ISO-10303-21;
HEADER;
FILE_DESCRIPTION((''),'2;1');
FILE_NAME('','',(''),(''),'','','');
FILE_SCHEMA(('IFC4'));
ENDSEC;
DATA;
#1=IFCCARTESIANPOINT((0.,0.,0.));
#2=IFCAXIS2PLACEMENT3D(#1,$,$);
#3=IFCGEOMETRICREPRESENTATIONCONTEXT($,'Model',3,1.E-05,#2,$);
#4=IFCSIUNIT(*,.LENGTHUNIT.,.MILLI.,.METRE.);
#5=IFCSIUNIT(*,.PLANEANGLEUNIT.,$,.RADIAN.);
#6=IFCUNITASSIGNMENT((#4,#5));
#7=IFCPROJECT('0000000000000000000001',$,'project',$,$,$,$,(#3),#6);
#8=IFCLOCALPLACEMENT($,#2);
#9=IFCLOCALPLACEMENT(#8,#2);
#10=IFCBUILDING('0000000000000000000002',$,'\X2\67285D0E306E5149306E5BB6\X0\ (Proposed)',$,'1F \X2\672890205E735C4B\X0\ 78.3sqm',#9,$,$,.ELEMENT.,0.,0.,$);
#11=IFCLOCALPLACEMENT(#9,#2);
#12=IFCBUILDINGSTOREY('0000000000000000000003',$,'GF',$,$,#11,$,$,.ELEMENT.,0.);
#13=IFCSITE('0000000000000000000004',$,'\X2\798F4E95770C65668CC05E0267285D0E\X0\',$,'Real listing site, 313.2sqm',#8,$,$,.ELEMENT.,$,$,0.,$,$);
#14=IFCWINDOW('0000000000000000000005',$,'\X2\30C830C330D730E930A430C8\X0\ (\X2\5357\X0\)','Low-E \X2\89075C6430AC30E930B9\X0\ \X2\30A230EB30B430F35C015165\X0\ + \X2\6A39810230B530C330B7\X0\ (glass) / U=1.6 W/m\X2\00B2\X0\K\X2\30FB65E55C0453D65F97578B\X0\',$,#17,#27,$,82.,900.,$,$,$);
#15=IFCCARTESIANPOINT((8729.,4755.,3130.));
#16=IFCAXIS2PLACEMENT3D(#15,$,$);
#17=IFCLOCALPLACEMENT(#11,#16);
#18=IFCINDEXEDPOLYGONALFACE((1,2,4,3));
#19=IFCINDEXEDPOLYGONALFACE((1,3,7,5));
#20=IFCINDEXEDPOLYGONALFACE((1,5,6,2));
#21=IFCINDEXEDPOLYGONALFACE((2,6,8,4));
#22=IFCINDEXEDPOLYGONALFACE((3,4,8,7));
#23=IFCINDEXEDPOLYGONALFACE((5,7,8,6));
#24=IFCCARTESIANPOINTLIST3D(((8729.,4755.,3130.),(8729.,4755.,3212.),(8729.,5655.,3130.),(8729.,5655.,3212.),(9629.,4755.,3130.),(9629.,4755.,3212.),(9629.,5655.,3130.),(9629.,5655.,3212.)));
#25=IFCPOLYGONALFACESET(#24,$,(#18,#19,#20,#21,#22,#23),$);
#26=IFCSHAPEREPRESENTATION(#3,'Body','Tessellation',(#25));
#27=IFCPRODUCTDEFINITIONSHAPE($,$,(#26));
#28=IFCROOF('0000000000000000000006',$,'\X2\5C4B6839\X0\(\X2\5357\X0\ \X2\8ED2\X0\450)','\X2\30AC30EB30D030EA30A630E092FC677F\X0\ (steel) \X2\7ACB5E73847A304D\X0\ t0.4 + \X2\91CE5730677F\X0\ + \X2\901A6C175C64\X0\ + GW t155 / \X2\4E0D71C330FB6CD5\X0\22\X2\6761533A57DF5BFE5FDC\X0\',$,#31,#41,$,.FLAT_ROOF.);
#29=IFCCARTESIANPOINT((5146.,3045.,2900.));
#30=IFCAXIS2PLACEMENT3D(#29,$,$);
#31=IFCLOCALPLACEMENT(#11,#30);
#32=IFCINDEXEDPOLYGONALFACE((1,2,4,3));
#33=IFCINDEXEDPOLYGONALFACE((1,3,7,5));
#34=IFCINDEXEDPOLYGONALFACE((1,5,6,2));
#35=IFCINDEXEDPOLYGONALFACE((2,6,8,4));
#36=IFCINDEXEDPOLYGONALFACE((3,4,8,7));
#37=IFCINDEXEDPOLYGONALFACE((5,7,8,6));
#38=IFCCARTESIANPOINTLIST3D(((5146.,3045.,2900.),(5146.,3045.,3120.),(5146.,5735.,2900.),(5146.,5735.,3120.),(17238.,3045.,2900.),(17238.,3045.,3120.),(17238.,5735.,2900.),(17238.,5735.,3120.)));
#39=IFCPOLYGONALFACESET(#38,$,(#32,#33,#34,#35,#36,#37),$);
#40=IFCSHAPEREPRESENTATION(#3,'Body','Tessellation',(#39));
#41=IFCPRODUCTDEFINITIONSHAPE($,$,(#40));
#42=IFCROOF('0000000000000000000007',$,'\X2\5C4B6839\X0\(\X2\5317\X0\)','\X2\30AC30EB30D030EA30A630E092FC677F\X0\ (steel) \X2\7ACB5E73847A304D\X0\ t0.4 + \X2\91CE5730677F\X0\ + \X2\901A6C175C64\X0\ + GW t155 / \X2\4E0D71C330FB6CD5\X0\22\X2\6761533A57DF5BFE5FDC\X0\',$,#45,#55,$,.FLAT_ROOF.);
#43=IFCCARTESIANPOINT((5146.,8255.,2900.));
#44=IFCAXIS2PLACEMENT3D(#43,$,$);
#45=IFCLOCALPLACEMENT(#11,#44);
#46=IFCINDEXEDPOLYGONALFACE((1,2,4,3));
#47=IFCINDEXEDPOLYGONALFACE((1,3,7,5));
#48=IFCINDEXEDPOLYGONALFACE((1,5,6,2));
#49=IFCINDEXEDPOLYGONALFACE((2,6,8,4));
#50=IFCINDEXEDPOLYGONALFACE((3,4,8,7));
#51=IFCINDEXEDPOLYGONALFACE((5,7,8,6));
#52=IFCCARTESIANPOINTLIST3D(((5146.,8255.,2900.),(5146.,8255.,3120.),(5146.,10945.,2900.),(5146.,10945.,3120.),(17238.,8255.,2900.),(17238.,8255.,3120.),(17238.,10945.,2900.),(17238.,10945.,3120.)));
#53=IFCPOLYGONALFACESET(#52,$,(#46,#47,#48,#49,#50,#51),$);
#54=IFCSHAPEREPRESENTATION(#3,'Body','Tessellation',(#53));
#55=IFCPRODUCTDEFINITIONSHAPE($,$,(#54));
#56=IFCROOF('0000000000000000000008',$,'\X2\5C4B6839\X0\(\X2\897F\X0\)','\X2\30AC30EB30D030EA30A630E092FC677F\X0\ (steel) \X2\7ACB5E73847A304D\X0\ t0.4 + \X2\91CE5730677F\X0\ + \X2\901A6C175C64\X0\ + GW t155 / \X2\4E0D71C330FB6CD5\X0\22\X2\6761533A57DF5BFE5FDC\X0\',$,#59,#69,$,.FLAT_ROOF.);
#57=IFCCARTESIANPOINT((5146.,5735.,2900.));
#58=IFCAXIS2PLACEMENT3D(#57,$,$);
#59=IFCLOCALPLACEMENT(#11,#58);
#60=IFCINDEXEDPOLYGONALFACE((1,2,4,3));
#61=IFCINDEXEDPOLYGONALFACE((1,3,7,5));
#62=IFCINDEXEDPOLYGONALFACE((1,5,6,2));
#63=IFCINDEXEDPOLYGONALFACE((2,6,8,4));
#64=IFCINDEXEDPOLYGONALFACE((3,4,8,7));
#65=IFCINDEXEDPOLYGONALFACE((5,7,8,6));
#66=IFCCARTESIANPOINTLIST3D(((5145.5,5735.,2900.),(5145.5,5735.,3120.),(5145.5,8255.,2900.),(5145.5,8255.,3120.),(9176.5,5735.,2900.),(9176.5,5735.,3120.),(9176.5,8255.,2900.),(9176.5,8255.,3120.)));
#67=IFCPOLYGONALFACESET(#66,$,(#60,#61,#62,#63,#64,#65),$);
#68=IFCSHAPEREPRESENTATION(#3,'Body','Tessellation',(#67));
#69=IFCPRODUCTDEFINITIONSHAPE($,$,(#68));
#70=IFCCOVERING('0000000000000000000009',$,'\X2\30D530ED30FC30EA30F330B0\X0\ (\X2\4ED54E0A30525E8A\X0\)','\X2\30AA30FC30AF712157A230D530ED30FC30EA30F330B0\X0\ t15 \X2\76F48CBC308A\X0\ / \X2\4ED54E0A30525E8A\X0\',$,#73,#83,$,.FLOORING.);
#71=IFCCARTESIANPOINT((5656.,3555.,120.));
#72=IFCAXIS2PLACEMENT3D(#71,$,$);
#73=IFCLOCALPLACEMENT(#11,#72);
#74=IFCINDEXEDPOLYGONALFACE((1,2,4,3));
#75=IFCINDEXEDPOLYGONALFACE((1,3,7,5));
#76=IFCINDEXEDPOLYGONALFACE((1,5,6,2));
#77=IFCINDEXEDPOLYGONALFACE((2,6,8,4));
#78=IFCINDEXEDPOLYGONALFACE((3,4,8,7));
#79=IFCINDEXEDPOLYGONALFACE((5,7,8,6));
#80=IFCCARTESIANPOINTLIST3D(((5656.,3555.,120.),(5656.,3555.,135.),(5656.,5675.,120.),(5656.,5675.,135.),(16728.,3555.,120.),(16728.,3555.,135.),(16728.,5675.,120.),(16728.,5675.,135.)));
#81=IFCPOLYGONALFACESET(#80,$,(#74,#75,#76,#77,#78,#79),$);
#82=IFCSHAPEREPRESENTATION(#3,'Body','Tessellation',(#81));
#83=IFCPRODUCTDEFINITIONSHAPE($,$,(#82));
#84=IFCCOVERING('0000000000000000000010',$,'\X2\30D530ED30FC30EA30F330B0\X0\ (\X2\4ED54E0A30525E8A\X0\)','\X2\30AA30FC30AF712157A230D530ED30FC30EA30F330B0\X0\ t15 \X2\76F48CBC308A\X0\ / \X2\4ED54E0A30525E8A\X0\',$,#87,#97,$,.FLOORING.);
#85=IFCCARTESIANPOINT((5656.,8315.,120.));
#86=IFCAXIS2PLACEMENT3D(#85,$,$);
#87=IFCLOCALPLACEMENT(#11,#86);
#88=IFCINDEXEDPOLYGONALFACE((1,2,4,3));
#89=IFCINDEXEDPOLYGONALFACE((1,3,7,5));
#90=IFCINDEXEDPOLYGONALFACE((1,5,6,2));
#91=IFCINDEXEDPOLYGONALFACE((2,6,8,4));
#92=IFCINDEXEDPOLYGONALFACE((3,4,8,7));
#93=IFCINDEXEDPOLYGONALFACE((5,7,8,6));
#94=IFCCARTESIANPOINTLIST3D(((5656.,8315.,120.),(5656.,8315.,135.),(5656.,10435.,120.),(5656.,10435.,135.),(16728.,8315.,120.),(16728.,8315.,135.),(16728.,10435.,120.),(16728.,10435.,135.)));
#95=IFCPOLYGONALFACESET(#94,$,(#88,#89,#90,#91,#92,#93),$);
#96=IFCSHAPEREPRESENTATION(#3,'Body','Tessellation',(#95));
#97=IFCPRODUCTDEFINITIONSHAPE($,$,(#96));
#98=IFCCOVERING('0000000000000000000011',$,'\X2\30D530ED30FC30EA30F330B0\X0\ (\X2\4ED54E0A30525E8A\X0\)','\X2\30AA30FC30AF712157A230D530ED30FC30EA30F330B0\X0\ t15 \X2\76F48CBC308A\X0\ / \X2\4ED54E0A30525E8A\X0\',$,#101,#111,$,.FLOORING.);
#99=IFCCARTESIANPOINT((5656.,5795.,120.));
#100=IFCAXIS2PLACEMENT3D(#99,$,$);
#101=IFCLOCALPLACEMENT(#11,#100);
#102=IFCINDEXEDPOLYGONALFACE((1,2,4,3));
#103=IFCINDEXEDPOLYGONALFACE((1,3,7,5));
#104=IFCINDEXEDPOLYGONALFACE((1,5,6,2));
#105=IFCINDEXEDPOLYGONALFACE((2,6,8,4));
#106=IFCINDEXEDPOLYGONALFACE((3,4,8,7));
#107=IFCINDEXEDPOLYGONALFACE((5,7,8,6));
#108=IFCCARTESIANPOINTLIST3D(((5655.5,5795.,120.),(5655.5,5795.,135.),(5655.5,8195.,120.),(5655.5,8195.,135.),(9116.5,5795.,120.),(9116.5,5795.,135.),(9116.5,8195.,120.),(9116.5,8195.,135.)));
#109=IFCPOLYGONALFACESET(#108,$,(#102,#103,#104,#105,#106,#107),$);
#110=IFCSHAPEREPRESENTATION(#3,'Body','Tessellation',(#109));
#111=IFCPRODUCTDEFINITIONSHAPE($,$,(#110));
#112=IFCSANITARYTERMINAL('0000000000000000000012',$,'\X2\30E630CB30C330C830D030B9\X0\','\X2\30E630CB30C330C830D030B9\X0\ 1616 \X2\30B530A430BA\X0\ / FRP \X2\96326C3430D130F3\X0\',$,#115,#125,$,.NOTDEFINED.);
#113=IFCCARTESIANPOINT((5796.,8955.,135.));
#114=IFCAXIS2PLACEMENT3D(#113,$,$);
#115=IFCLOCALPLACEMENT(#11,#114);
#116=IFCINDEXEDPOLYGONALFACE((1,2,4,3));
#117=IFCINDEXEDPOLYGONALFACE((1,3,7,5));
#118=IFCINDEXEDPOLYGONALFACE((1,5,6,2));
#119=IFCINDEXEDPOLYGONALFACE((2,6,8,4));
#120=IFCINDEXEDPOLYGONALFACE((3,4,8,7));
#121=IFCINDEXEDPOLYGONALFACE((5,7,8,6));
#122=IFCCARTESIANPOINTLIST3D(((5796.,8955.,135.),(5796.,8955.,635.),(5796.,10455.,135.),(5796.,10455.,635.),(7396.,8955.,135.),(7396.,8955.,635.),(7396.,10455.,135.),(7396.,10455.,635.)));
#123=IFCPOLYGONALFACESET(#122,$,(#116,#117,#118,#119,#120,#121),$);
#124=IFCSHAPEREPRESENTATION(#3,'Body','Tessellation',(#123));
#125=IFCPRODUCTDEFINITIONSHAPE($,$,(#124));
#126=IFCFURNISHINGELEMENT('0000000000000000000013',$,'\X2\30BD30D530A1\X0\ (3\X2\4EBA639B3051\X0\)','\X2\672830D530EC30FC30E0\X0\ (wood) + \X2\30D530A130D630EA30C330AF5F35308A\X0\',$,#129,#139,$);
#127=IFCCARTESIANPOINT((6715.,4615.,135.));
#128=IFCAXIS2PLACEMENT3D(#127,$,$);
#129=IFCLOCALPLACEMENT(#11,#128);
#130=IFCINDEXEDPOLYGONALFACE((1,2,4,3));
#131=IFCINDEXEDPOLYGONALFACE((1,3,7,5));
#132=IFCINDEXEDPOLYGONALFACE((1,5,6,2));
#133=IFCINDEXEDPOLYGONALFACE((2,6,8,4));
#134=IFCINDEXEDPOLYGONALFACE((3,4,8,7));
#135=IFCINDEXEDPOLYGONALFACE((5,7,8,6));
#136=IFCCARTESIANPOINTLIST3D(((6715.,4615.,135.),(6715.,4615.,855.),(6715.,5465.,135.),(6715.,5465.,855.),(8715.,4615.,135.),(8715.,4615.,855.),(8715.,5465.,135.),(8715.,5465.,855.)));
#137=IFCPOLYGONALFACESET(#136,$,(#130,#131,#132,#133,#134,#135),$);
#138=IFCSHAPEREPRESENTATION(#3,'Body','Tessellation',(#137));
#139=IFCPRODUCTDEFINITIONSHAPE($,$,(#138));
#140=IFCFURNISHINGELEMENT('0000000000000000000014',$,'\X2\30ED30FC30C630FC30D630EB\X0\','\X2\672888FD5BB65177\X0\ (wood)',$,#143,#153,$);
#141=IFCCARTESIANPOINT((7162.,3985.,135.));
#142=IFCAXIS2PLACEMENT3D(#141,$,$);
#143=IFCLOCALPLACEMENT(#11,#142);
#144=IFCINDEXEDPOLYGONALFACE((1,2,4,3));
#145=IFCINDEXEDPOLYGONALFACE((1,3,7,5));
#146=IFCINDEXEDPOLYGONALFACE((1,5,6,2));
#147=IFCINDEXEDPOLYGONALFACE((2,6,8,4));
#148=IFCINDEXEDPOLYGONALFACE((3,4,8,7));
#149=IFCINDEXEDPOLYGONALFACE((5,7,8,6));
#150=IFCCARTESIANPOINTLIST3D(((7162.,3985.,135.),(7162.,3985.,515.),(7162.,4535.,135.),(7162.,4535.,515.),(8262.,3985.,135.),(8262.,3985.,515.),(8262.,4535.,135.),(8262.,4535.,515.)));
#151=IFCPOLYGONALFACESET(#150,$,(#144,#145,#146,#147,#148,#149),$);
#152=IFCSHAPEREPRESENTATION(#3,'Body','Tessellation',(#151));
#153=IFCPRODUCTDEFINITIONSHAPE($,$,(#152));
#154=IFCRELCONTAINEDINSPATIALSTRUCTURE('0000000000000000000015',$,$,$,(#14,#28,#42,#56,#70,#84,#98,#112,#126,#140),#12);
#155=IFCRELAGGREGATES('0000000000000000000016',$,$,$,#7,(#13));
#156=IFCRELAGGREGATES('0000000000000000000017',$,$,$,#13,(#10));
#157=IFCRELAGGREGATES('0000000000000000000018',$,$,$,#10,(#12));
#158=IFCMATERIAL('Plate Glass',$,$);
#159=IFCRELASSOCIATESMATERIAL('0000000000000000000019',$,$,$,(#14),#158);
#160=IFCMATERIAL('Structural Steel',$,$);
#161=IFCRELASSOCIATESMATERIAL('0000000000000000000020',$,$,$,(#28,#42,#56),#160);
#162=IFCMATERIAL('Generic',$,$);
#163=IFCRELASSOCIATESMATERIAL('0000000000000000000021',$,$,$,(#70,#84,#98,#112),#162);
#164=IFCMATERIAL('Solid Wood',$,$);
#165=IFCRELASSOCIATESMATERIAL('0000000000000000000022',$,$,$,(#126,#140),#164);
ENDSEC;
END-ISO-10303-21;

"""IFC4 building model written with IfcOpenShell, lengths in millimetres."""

from ifc_helpers import new_model, si_unit, frame, frame_2d, origin, place, context, project, spatial, rectangle, extrude, material, element, save


model = new_model("IFC4")

# Units and contexts
model_context = context("Model", 3, precision=1e-05, world=origin())
ifc_project = project(units=[si_unit("LENGTHUNIT", "METRE", prefix="MILLI"), si_unit("PLANEANGLEUNIT", "RADIAN")], contexts=[model_context])

# Site, building, storey
site_placement = place(None, origin())
site = spatial("IfcSite", under=ifc_project, at=site_placement, Name="福井県敦賀市木崎", ObjectType="Real listing site, 313.2sqm", CompositionType="ELEMENT", RefElevation=0.0)
building_placement = place(site_placement, origin())
building = spatial("IfcBuilding", under=site, at=building_placement, Name="木崎の光の家 (Proposed)", ObjectType="1F 木造平屋 78.3sqm", CompositionType="ELEMENT", ElevationOfRefHeight=0.0, ElevationOfTerrain=0.0)
storey_placement = place(building_placement, origin())
storey = spatial("IfcBuildingStorey", under=building, at=storey_placement, Name="GF", CompositionType="ELEMENT", Elevation=0.0)

# Shared definitions
ifc_material_1 = material(Name="Solid Wood")

# Shared definitions
ifc_material_2 = material(Name="Plate Glass")

# Window
window_1_placement = place(storey_placement, frame((8729.0, 4755.0, 3130.0)))
element("IfcWindow", 1, at=window_1_placement, inside=storey, material=ifc_material_2, Name="トップライト (南)", Description="Low-E 複層ガラス アルゴン封入 + 樹脂サッシ (glass) / U=1.6 W/m²K・日射取得型", OverallHeight=82.0, OverallWidth=900.0, context=model_context, shape_type="SweptSolid", body=[
    extrude(rectangle(XDim=900.0, YDim=900.0, at=frame_2d((450.0, 450.0))), frame((8729.0, 4755.0, 3130.0)), (0.0, 0.0, 1.0), 82.0),
])

# Roofs
ifc_material_3 = material(Name="Structural Steel")
roof_1_placement = place(storey_placement, frame((5146.0, 3045.0, 2900.0)))
element("IfcRoof", 2, at=roof_1_placement, inside=storey, material=ifc_material_3, Name="屋根(南 軒450)", Description="ガルバリウム鋼板 (steel) 立平葺き t0.4 + 野地板 + 通気層 + GW t155 / 不燃・法22条区域対応", PredefinedType="FLAT_ROOF", context=model_context, shape_type="SweptSolid", body=[
    extrude(rectangle(XDim=12092.0, YDim=2690.0, at=frame_2d((6046.0, 1345.0))), frame((5146.0, 3045.0, 2900.0)), (0.0, 0.0, 1.0), 220.0),
])
roof_2_placement = place(storey_placement, frame((5146.0, 8255.0, 2900.0)))
element("IfcRoof", 3, at=roof_2_placement, inside=storey, material=ifc_material_3, Name="屋根(北)", Description="ガルバリウム鋼板 (steel) 立平葺き t0.4 + 野地板 + 通気層 + GW t155 / 不燃・法22条区域対応", PredefinedType="FLAT_ROOF", context=model_context, shape_type="SweptSolid", body=[
    extrude(rectangle(XDim=12092.0, YDim=2690.0, at=frame_2d((6046.0, 1345.0))), frame((5146.0, 8255.0, 2900.0)), (0.0, 0.0, 1.0), 220.0),
])
roof_3_placement = place(storey_placement, frame((5146.0, 5735.0, 2900.0)))
element("IfcRoof", 4, at=roof_3_placement, inside=storey, material=ifc_material_3, Name="屋根(西)", Description="ガルバリウム鋼板 (steel) 立平葺き t0.4 + 野地板 + 通気層 + GW t155 / 不燃・法22条区域対応", PredefinedType="FLAT_ROOF", context=model_context, shape_type="SweptSolid", body=[
    extrude(rectangle(XDim=4031.0, YDim=2520.0, at=frame_2d((2015.0, 1260.0))), frame((5146.0, 5735.0, 2900.0)), (0.0, 0.0, 1.0), 220.0),
])

# Coverings
ifc_material_4 = material(Name="Generic")
covering_1_placement = place(storey_placement, frame((5656.0, 3555.0, 120.0)))
element("IfcCovering", 5, at=covering_1_placement, inside=storey, material=ifc_material_4, Name="フローリング (仕上げ床)", Description="オーク無垢フローリング t15 直貼り / 仕上げ床", PredefinedType="FLOORING", context=model_context, shape_type="SweptSolid", body=[
    extrude(rectangle(XDim=11072.0, YDim=2120.0, at=frame_2d((5536.0, 1060.0))), frame((5656.0, 3555.0, 120.0)), (0.0, 0.0, 1.0), 15.0),
])
covering_2_placement = place(storey_placement, frame((5656.0, 8315.0, 120.0)))
element("IfcCovering", 6, at=covering_2_placement, inside=storey, material=ifc_material_4, Name="フローリング (仕上げ床)", Description="オーク無垢フローリング t15 直貼り / 仕上げ床", PredefinedType="FLOORING", context=model_context, shape_type="SweptSolid", body=[
    extrude(rectangle(XDim=11072.0, YDim=2120.0, at=frame_2d((5536.0, 1060.0))), frame((5656.0, 8315.0, 120.0)), (0.0, 0.0, 1.0), 15.0),
])
covering_3_placement = place(storey_placement, frame((5656.0, 5795.0, 120.0)))
element("IfcCovering", 7, at=covering_3_placement, inside=storey, material=ifc_material_4, Name="フローリング (仕上げ床)", Description="オーク無垢フローリング t15 直貼り / 仕上げ床", PredefinedType="FLOORING", context=model_context, shape_type="SweptSolid", body=[
    extrude(rectangle(XDim=3461.0, YDim=2400.0, at=frame_2d((1730.0, 1200.0))), frame((5656.0, 5795.0, 120.0)), (0.0, 0.0, 1.0), 15.0),
])

# Sanitary terminal
sanitary_terminal_placement = place(storey_placement, frame((5796.0, 8955.0, 135.0)))
element("IfcSanitaryTerminal", 8, at=sanitary_terminal_placement, inside=storey, material=ifc_material_4, Name="ユニットバス", Description="ユニットバス 1616 サイズ / FRP 防水パン", PredefinedType="NOTDEFINED", context=model_context, shape_type="SweptSolid", body=[
    extrude(rectangle(XDim=1600.0, YDim=1500.0, at=frame_2d((800.0, 750.0))), frame((5796.0, 8955.0, 135.0)), (0.0, 0.0, 1.0), 500.0),
])

# Furnishing elements
furnishing_1_placement = place(storey_placement, frame((6715.0, 4615.0, 135.0)))
element("IfcFurnishingElement", 9, at=furnishing_1_placement, inside=storey, material=ifc_material_1, Name="ソファ (3人掛け)", Description="木フレーム (wood) + ファブリック張り", context=model_context, shape_type="SweptSolid", body=[
    extrude(rectangle(XDim=2000.0, YDim=850.0, at=frame_2d((1000.0, 425.0))), frame((6715.0, 4615.0, 135.0)), (0.0, 0.0, 1.0), 720.0),
])
furnishing_2_placement = place(storey_placement, frame((7162.0, 3985.0, 135.0)))
element("IfcFurnishingElement", 10, at=furnishing_2_placement, inside=storey, material=ifc_material_1, Name="ローテーブル", Description="木製家具 (wood)", context=model_context, shape_type="SweptSolid", body=[
    extrude(rectangle(XDim=1100.0, YDim=550.0, at=frame_2d((550.0, 275.0))), frame((7162.0, 3985.0, 135.0)), (0.0, 0.0, 1.0), 380.0),
])

save(model, "model.ifc")
